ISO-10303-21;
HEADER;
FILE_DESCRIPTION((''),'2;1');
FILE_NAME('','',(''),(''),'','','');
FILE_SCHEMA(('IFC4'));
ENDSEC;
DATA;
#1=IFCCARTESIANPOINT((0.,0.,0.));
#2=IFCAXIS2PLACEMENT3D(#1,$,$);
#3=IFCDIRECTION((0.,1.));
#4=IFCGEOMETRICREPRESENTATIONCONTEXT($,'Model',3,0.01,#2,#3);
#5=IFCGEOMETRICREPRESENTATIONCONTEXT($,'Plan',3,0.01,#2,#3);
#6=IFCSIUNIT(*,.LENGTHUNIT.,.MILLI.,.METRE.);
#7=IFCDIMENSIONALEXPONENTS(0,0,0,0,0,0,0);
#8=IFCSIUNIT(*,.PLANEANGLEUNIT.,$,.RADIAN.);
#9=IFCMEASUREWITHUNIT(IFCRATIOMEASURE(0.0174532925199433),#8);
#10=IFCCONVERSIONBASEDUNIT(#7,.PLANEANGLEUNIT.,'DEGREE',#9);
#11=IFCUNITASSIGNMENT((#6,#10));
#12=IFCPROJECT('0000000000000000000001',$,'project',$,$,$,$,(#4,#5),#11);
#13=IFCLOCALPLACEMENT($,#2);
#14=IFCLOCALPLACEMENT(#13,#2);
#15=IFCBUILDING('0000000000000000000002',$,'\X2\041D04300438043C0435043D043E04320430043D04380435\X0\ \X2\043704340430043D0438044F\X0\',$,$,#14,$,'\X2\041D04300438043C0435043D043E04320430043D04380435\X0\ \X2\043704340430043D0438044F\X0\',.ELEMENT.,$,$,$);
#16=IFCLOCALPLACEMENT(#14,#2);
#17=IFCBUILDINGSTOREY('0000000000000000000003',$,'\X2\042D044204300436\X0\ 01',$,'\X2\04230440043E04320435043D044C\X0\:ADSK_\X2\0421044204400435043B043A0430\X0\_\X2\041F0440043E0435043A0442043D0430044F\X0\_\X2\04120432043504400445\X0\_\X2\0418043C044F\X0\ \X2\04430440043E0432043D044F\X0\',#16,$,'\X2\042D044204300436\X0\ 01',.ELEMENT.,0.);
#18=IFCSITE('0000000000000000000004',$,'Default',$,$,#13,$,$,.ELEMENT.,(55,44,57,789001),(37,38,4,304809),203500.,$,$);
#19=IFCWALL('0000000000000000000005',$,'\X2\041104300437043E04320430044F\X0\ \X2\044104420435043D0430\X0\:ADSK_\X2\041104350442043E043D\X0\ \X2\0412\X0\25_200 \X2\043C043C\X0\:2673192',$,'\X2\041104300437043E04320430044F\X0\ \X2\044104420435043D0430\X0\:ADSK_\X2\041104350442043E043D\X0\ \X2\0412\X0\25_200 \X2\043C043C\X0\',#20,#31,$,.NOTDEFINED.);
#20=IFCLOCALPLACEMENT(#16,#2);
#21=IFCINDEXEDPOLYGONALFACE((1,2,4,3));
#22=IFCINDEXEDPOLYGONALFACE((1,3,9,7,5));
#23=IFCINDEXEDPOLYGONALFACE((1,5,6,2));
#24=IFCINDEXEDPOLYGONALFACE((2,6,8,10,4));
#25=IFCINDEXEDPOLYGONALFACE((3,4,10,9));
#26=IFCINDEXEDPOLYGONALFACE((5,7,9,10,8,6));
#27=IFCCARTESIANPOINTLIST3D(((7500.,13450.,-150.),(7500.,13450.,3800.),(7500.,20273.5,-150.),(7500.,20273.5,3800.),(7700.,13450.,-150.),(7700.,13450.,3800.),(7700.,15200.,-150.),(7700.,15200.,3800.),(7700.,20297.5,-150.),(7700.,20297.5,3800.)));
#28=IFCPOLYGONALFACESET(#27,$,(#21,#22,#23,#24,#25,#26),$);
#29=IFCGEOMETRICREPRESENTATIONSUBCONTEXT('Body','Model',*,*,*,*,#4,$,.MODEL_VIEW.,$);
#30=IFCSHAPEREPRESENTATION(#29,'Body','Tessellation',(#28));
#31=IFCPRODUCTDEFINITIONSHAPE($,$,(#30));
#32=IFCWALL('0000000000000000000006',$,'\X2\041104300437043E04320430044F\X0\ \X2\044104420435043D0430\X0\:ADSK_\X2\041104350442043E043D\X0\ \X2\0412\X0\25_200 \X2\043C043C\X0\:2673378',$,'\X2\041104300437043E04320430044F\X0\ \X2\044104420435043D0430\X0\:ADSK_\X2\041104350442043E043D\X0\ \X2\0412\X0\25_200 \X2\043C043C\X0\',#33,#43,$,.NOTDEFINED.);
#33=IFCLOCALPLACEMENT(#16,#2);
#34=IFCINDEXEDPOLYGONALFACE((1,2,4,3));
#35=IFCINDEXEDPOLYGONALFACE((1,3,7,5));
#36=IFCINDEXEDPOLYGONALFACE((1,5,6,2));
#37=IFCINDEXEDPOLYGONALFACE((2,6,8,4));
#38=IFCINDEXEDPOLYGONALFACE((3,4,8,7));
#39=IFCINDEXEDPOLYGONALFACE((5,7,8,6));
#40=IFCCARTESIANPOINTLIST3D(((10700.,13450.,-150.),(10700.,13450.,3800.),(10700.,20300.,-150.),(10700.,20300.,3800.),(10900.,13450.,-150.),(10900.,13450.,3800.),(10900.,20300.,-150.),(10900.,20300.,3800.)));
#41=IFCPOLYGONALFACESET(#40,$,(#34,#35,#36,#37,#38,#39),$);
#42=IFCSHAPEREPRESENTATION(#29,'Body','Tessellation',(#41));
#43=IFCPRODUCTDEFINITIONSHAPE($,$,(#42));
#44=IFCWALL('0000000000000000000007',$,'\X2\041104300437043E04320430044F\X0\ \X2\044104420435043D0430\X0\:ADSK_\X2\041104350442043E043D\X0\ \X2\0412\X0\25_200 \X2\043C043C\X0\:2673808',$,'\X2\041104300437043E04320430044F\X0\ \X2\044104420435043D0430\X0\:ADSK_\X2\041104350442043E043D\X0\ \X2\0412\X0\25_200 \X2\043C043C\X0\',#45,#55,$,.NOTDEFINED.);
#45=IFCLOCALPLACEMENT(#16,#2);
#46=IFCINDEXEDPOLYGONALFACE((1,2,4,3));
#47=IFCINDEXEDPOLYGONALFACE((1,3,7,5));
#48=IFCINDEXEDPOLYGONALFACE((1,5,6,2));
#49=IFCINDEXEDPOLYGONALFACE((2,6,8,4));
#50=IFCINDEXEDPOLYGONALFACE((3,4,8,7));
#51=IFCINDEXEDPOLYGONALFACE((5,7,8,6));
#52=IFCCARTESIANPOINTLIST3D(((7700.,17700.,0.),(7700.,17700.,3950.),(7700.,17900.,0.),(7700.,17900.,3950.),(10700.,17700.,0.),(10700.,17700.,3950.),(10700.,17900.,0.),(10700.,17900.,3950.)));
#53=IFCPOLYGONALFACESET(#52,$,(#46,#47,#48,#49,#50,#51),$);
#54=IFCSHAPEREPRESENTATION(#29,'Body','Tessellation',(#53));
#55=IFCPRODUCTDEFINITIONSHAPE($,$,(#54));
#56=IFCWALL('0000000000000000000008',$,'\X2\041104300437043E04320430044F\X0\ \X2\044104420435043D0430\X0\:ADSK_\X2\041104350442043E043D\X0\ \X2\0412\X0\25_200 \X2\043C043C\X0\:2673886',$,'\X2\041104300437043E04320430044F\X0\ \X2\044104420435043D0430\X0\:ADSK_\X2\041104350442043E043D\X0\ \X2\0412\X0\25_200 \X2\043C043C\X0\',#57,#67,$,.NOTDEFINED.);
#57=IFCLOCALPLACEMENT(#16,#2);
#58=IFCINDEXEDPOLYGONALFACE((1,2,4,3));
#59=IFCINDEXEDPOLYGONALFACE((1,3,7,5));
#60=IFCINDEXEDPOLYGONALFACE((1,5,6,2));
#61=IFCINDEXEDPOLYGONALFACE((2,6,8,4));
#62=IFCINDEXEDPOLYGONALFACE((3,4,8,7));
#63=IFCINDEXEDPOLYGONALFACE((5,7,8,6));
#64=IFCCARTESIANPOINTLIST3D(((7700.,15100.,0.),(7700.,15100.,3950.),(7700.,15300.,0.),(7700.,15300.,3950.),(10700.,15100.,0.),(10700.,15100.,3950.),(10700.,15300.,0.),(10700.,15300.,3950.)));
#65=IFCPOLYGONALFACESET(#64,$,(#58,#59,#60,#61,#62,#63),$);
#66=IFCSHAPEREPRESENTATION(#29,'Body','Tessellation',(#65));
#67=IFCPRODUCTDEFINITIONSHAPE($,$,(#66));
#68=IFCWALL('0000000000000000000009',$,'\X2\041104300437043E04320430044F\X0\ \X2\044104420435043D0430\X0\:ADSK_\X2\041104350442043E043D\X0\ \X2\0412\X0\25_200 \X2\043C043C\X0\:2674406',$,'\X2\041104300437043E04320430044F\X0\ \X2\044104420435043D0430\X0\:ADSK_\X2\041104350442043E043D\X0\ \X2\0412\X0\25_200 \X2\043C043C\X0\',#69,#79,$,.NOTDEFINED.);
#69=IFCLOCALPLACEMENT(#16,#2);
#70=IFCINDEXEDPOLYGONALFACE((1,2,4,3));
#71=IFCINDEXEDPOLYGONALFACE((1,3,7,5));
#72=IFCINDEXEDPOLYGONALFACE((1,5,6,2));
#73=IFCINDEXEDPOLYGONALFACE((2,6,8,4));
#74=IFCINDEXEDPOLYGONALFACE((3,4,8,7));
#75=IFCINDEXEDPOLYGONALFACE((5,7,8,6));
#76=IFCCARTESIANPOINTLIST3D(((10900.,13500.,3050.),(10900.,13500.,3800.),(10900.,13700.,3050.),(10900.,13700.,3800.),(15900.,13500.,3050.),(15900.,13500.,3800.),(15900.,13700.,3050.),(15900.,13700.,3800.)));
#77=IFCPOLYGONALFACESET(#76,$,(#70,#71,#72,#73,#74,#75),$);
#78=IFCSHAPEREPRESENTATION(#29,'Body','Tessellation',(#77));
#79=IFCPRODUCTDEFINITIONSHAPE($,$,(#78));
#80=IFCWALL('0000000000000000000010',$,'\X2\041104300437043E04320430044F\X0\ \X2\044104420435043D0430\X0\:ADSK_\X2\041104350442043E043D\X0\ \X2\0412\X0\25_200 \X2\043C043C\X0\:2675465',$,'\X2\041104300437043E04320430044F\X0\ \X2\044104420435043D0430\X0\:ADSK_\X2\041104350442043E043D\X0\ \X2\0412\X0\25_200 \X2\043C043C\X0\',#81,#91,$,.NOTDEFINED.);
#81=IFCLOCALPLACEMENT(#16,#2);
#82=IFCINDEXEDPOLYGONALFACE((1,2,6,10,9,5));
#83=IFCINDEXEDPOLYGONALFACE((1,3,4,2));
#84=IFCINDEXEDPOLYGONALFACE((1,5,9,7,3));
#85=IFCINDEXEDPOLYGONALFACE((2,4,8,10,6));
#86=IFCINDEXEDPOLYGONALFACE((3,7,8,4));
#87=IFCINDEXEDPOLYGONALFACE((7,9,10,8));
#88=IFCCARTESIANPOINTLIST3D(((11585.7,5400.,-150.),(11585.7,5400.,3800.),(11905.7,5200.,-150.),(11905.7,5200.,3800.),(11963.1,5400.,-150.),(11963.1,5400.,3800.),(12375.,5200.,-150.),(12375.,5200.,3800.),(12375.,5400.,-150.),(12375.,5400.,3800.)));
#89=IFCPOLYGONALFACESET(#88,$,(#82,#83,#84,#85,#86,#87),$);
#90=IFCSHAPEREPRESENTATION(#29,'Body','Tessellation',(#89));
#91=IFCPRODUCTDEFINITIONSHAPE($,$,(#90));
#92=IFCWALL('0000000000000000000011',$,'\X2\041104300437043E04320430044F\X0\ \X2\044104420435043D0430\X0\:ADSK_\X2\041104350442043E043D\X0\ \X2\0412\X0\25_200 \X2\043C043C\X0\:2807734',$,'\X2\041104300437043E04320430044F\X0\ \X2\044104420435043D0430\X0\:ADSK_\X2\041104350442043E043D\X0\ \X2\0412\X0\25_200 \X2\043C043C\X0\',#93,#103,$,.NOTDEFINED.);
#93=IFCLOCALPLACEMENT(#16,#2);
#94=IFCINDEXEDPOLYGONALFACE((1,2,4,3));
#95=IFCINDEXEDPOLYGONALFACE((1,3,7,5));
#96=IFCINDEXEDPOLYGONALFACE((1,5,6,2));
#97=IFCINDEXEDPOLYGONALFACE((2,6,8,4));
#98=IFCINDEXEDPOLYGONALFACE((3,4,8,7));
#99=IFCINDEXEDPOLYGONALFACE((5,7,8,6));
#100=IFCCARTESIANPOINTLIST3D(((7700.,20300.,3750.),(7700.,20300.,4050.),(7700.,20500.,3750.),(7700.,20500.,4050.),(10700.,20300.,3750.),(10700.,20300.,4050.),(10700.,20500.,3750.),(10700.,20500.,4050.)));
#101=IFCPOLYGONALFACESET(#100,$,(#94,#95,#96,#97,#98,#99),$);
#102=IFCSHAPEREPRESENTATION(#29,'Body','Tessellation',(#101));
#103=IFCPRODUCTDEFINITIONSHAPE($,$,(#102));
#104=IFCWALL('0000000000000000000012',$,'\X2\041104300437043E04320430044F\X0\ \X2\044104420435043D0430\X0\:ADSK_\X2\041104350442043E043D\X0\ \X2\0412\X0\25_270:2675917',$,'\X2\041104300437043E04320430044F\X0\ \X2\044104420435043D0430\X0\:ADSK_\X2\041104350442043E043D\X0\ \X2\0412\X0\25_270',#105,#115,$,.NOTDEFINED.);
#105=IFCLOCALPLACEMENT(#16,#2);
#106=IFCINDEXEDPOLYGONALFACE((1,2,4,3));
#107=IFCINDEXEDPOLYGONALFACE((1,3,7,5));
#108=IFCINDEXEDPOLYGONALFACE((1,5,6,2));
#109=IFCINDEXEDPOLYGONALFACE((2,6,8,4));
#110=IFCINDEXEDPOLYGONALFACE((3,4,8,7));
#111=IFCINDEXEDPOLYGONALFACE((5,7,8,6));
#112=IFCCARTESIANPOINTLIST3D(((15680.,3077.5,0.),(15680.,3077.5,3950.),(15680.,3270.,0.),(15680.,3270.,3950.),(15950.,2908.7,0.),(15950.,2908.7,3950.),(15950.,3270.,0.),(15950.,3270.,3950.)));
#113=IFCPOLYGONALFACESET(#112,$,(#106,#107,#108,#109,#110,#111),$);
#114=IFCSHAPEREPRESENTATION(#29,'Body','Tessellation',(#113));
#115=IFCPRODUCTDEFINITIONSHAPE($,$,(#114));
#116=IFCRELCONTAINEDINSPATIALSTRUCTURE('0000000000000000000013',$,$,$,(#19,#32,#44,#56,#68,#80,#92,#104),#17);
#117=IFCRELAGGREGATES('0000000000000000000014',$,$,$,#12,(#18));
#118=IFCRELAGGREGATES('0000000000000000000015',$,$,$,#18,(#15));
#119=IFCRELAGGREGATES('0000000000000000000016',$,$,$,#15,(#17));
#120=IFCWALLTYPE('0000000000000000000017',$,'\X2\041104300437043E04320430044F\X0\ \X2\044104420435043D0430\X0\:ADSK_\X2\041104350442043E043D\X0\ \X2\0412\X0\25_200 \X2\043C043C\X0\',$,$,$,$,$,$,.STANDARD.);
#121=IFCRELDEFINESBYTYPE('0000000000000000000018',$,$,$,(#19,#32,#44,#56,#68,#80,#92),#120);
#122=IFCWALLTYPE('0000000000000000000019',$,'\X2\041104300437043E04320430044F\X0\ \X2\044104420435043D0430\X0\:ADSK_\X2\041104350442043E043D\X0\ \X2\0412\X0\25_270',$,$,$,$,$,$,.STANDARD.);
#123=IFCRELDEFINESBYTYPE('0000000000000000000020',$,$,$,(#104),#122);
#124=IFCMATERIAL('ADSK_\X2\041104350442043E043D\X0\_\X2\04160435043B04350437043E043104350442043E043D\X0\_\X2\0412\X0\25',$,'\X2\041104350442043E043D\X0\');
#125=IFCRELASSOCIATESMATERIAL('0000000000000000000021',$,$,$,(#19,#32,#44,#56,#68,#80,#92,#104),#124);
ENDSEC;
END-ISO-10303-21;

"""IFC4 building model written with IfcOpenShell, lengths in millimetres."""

from ifc_helpers import new_model, entity, si_unit, converted_unit, direction, frame, origin, place, context, subcontext, project, spatial, indexed_curve, outline, extrude, material, type_object, element, save


model = new_model("IFC4")

# Units and contexts
model_context = context("Model", 3, precision=0.01, world=origin(), true_north=direction((0.0, 1.0)))
plan_context = context("Plan", 3, precision=0.01, world=origin(), true_north=direction((0.0, 1.0)))
body_context = subcontext(model_context, "Body", "Model", "MODEL_VIEW")
ifc_project = project(units=[si_unit("LENGTHUNIT", "METRE", prefix="MILLI"), converted_unit("PLANEANGLEUNIT", "DEGREE", entity("IfcRatioMeasure", 0.0174532925199433), si_unit("PLANEANGLEUNIT", "RADIAN"), dimensions=[0, 0, 0, 0, 0, 0, 0])], contexts=[model_context, plan_context])

# Site, building, storey
site_placement = place(None, origin())
site = spatial("IfcSite", under=ifc_project, at=site_placement, Name="Default", CompositionType="ELEMENT", RefLatitude=(55, 44, 57, 789001), RefLongitude=(37, 38, 4, 304809), RefElevation=203500.0)
building_placement = place(site_placement, origin())
building = spatial("IfcBuilding", under=site, at=building_placement, Name="Наименование здания", LongName="Наименование здания", CompositionType="ELEMENT")
storey_placement = place(building_placement, origin())
storey = spatial("IfcBuildingStorey", under=building, at=storey_placement, Name="Этаж 01", ObjectType="Уровень:ADSK_Стрелка_Проектная_Вверх_Имя уровня", LongName="Этаж 01", CompositionType="ELEMENT", Elevation=0.0)

# Shared definitions
ifc_material = material(Name="ADSK_Бетон_Железобетон_В25", Category="Бетон")

# Walls
wall_type_1 = type_object("IfcWallType", Name="Базовая стена:ADSK_Бетон В25_200 мм", PredefinedType="STANDARD")
wall_1_placement = place(storey_placement, frame((7600.0, 20297.5, -150.0), z_axis=(0.0, 0.0, 1.0), x_axis=(0.0, -1.0, 0.0)))
element("IfcWall", 1, at=wall_1_placement, inside=storey, type_object=wall_type_1, material=ifc_material, Name="Базовая стена:ADSK_Бетон В25_200 мм:2673192", ObjectType="Базовая стена:ADSK_Бетон В25_200 мм", PredefinedType="NOTDEFINED", context=body_context, shape_type="SweptSolid", body=[
    extrude(outline(indexed_curve([(6847.5, -100.0), (6847.5, 100.0), (5097.5, 100.0), (0.0, 100.0), (24.0, -100.0), (6847.5, -100.0)], self_intersect=False)), origin(), (0.0, 0.0, 1.0), 3950.0),
])
wall_2_placement = place(storey_placement, frame((10800.0, 20300.0, -150.0), z_axis=(0.0, 0.0, 1.0), x_axis=(0.0, -1.0, 0.0)))
element("IfcWall", 2, at=wall_2_placement, inside=storey, type_object=wall_type_1, material=ifc_material, Name="Базовая стена:ADSK_Бетон В25_200 мм:2673378", ObjectType="Базовая стена:ADSK_Бетон В25_200 мм", PredefinedType="NOTDEFINED", context=body_context, shape_type="SweptSolid", body=[
    extrude(outline(indexed_curve([(6850.0, 100.0), (0.0, 100.0), (0.0, -100.0), (6850.0, -100.0), (6850.0, 100.0)], self_intersect=False)), origin(), (0.0, 0.0, 1.0), 3950.0),
])
for number, where, z_axis, x_axis, name in (
    (3, (10700.0, 17800.0, 0.0), (0.0, 0.0, 1.0), (-1.0, 0.0, 0.0), "Базовая стена:ADSK_Бетон В25_200 мм:2673808"),
    (4, (10700.0, 15200.0, 0.0), (0.0, 0.0, 1.0), (-1.0, 0.0, 0.0), "Базовая стена:ADSK_Бетон В25_200 мм:2673886"),
):
    element("IfcWall", number, at=place(storey_placement, frame(where, z_axis=z_axis, x_axis=x_axis)), inside=storey, type_object=wall_type_1, material=ifc_material, Name=name, ObjectType="Базовая стена:ADSK_Бетон В25_200 мм", PredefinedType="NOTDEFINED", context=body_context, shape_type="SweptSolid", body=[
        extrude(outline(indexed_curve([(3000.0, 100.0), (0.0, 100.0), (0.0, -100.0), (3000.0, -100.0), (3000.0, 100.0)], self_intersect=False)), origin(), (0.0, 0.0, 1.0), 3950.0),
    ])
wall_3_placement = place(storey_placement, frame((15900.0, 13600.0, 3050.0), z_axis=(0.0, 0.0, 1.0), x_axis=(-1.0, 0.0, 0.0)))
element("IfcWall", 5, at=wall_3_placement, inside=storey, type_object=wall_type_1, material=ifc_material, Name="Базовая стена:ADSK_Бетон В25_200 мм:2674406", ObjectType="Базовая стена:ADSK_Бетон В25_200 мм", PredefinedType="NOTDEFINED", context=body_context, shape_type="SweptSolid", body=[
    extrude(outline(indexed_curve([(5000.0, 100.0), (0.0, 100.0), (0.0, -100.0), (5000.0, -100.0), (5000.0, 100.0)], self_intersect=False)), origin(), (0.0, 0.0, 1.0), 750.0),
])
wall_4_placement = place(storey_placement, frame((12375.0, 5300.0, -150.0), z_axis=(0.0, 0.0, 1.0), x_axis=(-1.0, 0.0, 0.0)))
element("IfcWall", 6, at=wall_4_placement, inside=storey, type_object=wall_type_1, material=ifc_material, Name="Базовая стена:ADSK_Бетон В25_200 мм:2675465", ObjectType="Базовая стена:ADSK_Бетон В25_200 мм", PredefinedType="NOTDEFINED", context=body_context, shape_type="SweptSolid", body=[
    extrude(outline(indexed_curve([(789.3, -100.0), (469.3, 100.0), (0.0, 100.0), (0.0, -100.0), (411.9, -100.0), (789.3, -100.0)], self_intersect=False)), origin(), (0.0, 0.0, 1.0), 3950.0),
])
wall_5_placement = place(storey_placement, frame((7700.0, 20400.0, 3750.0)))
element("IfcWall", 7, at=wall_5_placement, inside=storey, type_object=wall_type_1, material=ifc_material, Name="Базовая стена:ADSK_Бетон В25_200 мм:2807734", ObjectType="Базовая стена:ADSK_Бетон В25_200 мм", PredefinedType="NOTDEFINED", context=body_context, shape_type="SweptSolid", body=[
    extrude(outline(indexed_curve([(3000.0, 100.0), (0.0, 100.0), (0.0, -100.0), (3000.0, -100.0), (3000.0, 100.0)], self_intersect=False)), origin(), (0.0, 0.0, 1.0), 300.0),
])
wall_type_2 = type_object("IfcWallType", Name="Базовая стена:ADSK_Бетон В25_270", PredefinedType="STANDARD")
wall_6_placement = place(storey_placement, frame((15815.0, 3270.0, 0.0), z_axis=(0.0, 0.0, 1.0), x_axis=(0.0, -1.0, 0.0)))
element("IfcWall", 8, at=wall_6_placement, inside=storey, type_object=wall_type_2, material=ifc_material, Name="Базовая стена:ADSK_Бетон В25_270:2675917", ObjectType="Базовая стена:ADSK_Бетон В25_270", PredefinedType="NOTDEFINED", context=body_context, shape_type="SweptSolid", body=[
    extrude(outline(indexed_curve([(192.5, -135.0), (361.3, 135.0), (0.0, 135.0), (0.0, -135.0), (192.5, -135.0)], self_intersect=False)), origin(), (0.0, 0.0, 1.0), 3950.0),
])

save(model, "model.ifc")
